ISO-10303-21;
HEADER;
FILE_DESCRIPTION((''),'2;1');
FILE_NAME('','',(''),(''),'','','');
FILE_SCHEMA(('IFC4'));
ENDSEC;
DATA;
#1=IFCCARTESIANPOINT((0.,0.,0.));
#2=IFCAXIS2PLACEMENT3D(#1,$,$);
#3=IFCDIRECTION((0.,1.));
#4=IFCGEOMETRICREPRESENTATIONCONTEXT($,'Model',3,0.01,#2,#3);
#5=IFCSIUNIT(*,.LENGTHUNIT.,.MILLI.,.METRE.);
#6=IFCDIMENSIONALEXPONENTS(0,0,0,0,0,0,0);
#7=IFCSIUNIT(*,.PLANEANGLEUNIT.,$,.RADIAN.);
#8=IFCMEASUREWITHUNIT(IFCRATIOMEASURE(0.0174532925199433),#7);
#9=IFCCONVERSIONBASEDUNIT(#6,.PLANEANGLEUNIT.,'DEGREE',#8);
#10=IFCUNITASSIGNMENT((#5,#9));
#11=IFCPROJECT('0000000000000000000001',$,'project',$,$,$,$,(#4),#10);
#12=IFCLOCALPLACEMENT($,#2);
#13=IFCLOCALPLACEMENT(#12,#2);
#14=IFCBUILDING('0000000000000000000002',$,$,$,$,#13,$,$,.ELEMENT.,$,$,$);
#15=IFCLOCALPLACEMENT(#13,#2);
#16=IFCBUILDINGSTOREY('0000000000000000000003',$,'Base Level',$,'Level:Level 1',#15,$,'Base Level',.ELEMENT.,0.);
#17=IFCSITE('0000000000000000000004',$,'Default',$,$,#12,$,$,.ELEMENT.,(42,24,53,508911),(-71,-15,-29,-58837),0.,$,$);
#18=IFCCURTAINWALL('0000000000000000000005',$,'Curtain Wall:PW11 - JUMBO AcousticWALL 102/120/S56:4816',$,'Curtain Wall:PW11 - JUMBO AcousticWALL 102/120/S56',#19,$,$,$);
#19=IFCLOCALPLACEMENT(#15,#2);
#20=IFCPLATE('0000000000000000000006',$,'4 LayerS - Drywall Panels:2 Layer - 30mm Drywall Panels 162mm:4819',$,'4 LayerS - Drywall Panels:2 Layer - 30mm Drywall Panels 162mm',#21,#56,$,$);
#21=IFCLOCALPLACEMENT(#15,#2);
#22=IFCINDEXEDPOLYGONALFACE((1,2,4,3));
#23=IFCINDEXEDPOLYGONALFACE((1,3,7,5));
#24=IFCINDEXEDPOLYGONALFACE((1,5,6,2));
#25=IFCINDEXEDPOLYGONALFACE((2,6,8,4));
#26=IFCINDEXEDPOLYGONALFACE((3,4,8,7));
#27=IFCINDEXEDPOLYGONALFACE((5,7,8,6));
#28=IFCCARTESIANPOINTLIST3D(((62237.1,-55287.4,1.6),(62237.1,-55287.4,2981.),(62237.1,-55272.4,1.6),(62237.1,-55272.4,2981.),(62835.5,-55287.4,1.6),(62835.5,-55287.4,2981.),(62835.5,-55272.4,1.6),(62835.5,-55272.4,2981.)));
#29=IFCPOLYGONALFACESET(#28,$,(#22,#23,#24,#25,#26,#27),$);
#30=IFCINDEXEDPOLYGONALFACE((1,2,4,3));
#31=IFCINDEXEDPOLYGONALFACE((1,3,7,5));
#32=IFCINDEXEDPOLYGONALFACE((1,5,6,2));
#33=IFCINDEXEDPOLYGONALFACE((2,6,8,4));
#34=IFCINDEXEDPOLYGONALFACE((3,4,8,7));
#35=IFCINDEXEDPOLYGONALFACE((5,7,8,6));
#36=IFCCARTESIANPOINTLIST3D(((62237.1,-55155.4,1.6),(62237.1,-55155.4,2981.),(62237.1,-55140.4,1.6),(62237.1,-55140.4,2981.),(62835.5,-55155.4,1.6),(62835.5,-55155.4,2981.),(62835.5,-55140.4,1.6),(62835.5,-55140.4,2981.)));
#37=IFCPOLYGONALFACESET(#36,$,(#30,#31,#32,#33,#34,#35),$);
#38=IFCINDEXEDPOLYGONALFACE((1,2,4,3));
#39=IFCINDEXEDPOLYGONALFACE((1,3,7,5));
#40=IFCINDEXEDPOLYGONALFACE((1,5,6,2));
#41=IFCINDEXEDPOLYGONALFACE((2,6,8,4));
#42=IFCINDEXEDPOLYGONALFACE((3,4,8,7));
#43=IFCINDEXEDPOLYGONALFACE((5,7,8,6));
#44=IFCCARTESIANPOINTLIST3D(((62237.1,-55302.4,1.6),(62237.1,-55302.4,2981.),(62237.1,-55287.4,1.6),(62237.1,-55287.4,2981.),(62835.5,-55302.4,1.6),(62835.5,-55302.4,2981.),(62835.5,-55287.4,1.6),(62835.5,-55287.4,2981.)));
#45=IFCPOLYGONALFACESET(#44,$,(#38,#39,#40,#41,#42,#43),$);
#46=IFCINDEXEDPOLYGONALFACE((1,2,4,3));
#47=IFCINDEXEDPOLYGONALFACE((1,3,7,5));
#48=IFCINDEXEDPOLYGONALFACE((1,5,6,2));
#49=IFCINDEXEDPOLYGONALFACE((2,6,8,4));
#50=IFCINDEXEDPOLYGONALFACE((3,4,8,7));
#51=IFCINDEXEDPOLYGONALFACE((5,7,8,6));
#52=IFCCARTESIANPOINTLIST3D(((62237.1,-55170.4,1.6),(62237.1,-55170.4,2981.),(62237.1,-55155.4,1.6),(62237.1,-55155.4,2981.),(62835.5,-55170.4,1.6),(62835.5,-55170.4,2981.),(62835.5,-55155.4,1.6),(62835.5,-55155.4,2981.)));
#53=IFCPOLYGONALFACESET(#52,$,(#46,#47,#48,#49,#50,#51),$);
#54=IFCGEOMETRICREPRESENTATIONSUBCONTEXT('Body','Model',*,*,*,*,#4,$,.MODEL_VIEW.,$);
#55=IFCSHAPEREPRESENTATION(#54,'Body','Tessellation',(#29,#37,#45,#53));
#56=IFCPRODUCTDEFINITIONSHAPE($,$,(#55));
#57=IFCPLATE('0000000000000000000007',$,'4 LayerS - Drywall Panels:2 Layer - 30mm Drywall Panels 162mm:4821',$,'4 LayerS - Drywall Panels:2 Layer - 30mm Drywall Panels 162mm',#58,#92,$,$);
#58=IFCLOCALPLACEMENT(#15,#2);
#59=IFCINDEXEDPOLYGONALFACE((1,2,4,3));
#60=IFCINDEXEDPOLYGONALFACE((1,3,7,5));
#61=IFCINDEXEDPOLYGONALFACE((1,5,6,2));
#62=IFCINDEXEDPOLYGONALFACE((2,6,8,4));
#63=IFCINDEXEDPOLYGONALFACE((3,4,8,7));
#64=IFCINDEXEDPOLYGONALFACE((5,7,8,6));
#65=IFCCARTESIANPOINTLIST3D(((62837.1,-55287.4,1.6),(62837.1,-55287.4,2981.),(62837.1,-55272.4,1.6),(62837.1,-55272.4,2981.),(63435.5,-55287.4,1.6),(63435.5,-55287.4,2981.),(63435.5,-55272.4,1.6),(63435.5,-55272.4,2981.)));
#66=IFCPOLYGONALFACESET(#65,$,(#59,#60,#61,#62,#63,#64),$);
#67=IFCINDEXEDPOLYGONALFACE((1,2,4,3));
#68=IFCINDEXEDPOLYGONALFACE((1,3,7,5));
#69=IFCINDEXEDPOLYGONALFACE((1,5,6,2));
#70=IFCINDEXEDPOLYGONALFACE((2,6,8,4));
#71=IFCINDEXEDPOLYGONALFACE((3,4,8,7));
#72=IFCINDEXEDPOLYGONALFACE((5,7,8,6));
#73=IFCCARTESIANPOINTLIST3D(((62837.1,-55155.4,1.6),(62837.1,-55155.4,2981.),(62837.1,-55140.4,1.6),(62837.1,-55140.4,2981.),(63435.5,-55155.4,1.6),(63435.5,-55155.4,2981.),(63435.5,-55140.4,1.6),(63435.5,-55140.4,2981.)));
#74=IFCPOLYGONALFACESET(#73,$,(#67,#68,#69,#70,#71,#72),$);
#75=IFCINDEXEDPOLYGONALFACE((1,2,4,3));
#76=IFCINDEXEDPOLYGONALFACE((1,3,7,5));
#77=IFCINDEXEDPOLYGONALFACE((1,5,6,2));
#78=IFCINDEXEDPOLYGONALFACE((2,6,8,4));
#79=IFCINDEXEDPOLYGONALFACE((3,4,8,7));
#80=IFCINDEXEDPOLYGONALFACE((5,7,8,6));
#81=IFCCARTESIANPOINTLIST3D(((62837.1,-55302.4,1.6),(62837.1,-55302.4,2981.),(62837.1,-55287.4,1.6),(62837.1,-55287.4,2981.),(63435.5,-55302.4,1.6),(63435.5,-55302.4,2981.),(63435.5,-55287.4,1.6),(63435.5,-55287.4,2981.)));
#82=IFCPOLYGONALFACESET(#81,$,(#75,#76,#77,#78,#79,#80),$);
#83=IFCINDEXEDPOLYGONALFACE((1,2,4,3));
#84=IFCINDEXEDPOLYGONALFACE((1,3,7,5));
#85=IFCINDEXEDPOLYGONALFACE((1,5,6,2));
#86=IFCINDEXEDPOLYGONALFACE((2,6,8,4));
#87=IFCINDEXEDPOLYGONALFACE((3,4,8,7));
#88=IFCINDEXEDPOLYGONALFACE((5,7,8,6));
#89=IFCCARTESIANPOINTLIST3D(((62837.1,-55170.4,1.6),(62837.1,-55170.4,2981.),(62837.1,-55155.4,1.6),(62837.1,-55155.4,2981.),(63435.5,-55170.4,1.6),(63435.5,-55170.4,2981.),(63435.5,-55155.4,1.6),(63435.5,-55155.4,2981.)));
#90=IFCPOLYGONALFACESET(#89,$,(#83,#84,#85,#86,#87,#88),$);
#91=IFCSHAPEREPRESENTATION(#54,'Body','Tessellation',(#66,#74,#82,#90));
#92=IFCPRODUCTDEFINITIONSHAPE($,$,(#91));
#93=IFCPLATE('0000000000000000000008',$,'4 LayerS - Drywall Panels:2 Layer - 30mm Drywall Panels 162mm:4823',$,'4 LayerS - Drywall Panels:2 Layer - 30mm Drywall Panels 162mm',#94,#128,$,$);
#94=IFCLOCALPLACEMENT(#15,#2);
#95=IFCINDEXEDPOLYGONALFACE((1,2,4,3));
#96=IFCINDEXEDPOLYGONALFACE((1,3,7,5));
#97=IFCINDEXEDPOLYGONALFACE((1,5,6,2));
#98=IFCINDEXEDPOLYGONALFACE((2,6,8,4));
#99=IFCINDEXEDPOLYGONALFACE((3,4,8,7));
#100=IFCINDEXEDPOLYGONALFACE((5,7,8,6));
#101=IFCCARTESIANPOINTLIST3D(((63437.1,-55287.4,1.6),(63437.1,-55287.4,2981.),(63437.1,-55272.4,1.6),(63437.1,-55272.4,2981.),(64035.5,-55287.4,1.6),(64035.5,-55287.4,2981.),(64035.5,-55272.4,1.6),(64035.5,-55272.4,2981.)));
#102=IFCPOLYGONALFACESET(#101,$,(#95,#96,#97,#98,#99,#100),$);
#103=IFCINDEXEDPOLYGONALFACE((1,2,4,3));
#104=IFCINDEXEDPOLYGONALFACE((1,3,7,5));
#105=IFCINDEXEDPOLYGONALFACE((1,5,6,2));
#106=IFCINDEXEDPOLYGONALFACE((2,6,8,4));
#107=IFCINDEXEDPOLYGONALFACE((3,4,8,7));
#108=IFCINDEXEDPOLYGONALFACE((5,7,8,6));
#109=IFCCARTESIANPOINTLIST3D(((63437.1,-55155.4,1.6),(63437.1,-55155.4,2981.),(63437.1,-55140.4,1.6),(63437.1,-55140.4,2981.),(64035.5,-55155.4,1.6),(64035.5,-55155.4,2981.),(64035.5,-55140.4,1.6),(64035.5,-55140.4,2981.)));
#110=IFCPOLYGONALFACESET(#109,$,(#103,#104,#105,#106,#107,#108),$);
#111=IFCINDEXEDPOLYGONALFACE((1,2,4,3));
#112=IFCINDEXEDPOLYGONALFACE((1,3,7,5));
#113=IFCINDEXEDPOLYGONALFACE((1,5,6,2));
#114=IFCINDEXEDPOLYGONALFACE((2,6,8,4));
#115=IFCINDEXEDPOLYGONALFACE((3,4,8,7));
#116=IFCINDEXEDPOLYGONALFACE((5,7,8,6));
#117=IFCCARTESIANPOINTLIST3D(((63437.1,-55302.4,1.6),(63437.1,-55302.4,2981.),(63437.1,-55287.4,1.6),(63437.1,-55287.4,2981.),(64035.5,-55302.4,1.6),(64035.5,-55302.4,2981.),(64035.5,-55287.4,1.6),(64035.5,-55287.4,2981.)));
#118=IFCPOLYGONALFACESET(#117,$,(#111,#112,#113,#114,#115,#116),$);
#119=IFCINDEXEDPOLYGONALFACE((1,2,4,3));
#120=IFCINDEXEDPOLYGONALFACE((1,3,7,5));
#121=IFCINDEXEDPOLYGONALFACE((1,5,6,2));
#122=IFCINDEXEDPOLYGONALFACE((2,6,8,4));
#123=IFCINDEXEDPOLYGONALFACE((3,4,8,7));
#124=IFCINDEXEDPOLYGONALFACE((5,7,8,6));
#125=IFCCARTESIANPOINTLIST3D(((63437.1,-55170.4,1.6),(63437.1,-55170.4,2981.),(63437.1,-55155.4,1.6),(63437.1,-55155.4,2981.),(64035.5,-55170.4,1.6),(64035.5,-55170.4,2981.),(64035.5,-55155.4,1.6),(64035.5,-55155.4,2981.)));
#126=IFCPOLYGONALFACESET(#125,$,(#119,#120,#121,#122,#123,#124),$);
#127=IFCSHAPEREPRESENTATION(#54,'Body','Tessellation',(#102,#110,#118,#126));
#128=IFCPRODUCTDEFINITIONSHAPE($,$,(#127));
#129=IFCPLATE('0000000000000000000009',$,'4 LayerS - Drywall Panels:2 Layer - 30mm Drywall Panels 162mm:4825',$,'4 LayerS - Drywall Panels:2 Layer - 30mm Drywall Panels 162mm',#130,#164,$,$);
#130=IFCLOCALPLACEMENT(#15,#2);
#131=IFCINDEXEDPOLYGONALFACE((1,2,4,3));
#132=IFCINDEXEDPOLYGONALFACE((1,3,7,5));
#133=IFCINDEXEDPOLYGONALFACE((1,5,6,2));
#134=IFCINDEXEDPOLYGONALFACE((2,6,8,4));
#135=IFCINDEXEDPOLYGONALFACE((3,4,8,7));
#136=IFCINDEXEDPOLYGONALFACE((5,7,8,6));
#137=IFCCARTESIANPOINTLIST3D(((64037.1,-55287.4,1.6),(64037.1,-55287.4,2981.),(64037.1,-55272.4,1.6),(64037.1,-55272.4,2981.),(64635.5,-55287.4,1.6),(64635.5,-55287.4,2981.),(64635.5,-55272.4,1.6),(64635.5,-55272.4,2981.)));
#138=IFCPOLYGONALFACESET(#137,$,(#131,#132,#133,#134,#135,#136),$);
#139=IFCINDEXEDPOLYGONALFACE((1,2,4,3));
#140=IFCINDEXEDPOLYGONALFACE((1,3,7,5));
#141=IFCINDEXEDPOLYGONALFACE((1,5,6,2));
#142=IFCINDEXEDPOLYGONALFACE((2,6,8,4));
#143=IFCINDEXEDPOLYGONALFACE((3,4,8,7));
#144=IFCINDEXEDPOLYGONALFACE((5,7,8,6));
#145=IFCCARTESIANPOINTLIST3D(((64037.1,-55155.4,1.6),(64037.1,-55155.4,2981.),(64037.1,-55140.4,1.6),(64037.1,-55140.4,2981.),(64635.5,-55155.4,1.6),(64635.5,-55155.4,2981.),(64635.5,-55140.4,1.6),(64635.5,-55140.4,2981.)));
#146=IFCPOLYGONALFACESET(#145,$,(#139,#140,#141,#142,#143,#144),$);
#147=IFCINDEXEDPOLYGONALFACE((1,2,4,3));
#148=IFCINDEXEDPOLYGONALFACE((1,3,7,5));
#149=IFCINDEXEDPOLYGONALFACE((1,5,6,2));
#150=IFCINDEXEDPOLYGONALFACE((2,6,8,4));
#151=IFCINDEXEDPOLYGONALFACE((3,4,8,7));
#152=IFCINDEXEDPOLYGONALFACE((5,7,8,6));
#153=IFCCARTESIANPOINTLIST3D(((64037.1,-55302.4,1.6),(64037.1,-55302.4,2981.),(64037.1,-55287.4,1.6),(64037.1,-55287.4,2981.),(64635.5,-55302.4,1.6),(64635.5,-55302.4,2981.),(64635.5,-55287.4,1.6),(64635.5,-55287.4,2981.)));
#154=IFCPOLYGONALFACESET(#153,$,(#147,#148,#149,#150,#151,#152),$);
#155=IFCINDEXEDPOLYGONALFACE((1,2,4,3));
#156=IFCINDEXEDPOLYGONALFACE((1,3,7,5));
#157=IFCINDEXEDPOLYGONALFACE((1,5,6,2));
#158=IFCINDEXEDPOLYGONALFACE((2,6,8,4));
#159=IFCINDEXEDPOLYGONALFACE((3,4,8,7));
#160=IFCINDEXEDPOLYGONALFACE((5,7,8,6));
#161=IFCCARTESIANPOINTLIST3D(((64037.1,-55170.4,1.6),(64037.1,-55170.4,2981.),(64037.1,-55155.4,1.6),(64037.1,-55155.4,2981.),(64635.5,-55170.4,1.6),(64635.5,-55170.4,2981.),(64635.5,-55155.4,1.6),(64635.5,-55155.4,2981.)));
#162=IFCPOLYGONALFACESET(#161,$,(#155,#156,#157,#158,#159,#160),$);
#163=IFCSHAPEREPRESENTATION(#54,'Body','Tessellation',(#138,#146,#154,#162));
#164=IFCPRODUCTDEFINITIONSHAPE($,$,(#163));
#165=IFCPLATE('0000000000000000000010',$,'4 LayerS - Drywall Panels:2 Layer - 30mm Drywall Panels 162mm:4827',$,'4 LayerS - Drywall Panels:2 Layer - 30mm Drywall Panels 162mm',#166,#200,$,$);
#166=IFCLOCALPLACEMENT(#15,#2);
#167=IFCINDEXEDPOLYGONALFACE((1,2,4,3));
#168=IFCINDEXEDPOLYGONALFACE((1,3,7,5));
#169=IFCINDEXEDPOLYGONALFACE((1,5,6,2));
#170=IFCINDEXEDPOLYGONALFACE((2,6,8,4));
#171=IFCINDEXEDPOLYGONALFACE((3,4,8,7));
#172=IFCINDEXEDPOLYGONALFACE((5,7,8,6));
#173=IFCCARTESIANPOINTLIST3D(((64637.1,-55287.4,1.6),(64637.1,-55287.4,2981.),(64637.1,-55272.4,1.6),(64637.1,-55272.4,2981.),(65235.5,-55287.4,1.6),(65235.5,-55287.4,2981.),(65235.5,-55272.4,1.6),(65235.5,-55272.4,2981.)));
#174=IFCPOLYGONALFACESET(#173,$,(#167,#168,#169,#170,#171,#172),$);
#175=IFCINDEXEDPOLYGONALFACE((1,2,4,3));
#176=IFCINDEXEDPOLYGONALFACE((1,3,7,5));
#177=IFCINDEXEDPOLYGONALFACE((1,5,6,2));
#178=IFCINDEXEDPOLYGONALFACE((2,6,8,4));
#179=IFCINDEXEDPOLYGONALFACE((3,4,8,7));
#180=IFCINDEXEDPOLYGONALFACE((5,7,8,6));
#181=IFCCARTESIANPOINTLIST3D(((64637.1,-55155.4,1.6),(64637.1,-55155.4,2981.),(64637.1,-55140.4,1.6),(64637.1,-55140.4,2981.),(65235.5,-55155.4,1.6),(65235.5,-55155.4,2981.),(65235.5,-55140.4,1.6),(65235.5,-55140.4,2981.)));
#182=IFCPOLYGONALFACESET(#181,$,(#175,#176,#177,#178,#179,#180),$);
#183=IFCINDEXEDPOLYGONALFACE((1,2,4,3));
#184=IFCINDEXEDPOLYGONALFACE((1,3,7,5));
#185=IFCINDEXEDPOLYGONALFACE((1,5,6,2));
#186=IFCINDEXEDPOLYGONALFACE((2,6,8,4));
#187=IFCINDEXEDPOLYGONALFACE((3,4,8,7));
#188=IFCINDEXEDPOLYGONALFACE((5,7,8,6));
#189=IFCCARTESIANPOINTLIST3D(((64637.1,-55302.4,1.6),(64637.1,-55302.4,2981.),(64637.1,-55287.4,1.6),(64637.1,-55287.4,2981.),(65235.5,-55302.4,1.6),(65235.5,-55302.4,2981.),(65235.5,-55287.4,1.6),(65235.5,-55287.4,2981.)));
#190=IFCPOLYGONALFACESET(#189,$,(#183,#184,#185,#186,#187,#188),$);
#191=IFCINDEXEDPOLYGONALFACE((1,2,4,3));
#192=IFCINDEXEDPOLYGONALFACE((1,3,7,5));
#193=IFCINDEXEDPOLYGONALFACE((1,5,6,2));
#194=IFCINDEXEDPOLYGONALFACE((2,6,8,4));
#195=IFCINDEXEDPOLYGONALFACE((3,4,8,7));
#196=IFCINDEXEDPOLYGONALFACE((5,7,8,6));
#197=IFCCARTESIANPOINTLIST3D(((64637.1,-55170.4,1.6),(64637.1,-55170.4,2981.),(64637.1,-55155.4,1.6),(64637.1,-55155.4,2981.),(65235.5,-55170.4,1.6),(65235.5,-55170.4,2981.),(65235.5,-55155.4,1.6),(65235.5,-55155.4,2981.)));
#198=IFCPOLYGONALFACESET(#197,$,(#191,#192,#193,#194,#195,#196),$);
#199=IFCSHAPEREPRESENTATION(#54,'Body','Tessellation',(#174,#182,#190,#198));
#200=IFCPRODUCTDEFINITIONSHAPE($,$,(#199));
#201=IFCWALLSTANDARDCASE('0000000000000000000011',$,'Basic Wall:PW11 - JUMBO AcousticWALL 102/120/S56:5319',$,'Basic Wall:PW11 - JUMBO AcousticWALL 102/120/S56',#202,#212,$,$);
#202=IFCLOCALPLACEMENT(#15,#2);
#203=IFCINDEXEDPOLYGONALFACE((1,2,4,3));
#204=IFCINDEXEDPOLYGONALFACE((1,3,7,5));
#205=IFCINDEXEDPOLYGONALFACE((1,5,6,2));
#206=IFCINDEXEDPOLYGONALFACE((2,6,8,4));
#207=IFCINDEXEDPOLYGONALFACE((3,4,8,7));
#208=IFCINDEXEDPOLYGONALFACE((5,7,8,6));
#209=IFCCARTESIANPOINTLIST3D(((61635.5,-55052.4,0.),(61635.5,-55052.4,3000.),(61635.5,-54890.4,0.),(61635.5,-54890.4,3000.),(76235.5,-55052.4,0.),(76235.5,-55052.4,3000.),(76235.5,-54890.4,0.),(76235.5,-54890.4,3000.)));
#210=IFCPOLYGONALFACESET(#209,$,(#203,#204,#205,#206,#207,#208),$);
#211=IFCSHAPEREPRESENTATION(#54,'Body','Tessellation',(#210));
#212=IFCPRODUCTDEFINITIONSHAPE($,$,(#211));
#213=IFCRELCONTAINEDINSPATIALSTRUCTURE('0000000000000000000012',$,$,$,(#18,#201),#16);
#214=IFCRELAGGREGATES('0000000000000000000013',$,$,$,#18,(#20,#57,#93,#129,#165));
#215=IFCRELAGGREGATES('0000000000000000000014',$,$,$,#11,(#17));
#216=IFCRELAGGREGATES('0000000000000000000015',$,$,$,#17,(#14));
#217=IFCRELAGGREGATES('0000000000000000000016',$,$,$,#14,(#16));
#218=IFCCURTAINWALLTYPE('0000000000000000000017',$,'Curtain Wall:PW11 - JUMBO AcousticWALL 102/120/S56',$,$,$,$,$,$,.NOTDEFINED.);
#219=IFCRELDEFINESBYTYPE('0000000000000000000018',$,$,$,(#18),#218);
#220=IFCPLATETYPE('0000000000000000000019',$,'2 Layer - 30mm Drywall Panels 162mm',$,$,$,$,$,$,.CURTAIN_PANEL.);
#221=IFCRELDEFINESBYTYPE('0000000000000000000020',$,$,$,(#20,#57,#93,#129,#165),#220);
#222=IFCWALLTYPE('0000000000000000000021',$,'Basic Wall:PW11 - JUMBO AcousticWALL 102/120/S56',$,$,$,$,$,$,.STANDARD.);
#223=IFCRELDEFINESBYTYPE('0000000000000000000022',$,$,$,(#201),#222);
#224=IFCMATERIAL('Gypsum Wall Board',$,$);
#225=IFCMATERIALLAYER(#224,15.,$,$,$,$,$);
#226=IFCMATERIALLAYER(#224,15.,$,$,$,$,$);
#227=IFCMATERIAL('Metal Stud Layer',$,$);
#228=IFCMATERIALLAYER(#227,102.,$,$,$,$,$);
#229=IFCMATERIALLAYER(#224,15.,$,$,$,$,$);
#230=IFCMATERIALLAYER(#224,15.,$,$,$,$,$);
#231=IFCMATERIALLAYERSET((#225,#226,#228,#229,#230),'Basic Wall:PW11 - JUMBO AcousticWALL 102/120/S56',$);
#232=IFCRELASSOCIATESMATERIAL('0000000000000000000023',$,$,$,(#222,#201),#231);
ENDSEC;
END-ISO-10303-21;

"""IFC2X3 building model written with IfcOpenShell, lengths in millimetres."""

from ifc_helpers import new_model, entity, si_unit, converted_unit, direction, frame, frame_2d, origin, origin_2d_with_axis, place, context, subcontext, project, spatial, rectangle, extrude, source, transform, mapped, material, layer, layer_set, layer_usage, type_object, type_shapes, element, aggregate, save


model = new_model("IFC2X3")

# Units and contexts
model_context = context("Model", 3, precision=0.01, world=origin(), true_north=direction((0.0, 1.0)))
body_context = subcontext(model_context, "Body", "Model", "MODEL_VIEW")
ifc_project = project(units=[si_unit("LENGTHUNIT", "METRE", prefix="MILLI"), converted_unit("PLANEANGLEUNIT", "DEGREE", entity("IfcRatioMeasure", 0.0174532925199433), si_unit("PLANEANGLEUNIT", "RADIAN"), dimensions=[0, 0, 0, 0, 0, 0, 0])], contexts=[model_context])

# Site, building, storey
site_placement = place(None, origin())
site = spatial("IfcSite", under=ifc_project, at=site_placement, Name="Default", CompositionType="ELEMENT", RefLatitude=(42, 24, 53, 508911), RefLongitude=(-71, -15, -29, -58837), RefElevation=0.0)
building_placement = place(site_placement, origin())
building = spatial("IfcBuilding", under=site, at=building_placement, CompositionType="ELEMENT")
storey_placement = place(building_placement, origin())
storey = spatial("IfcBuildingStorey", under=building, at=storey_placement, Name="Base Level", ObjectType="Level:Level 1", LongName="Base Level", CompositionType="ELEMENT", Elevation=0.0)

# Curtain wall, plates
curtain_wall_type = type_object("IfcCurtainWallType", Name="Curtain Wall:PW11 - JUMBO AcousticWALL 102/120/S56", PredefinedType="NOTDEFINED")
curtain_wall_placement = place(building_placement, origin())
curtain_wall = element("IfcCurtainWall", 1, at=curtain_wall_placement, inside=storey, type_object=curtain_wall_type, Name="Curtain Wall:PW11 - JUMBO AcousticWALL 102/120/S56:4816", ObjectType="Curtain Wall:PW11 - JUMBO AcousticWALL 102/120/S56")
plate_type = type_object("IfcPlateType", Name="2 Layer - 30mm Drywall Panels 162mm", PredefinedType="CURTAIN_PANEL")
shared_shape_1 = source(origin(), body_context, "Body", "SweptSolid", [
    extrude(rectangle(XDim=15.0, YDim=598.4, at=origin_2d_with_axis()), frame((0.0, -58.5, 0.0), z_axis=(0.0, 0.0, 1.0), x_axis=(0.0, 1.0, 0.0)), (0.0, 0.0, 1.0), 2979.4),
    extrude(rectangle(XDim=15.0, YDim=598.4, at=frame_2d((0.0, 0.0), x_axis=(1.0, 0.0))), frame((0.0, 73.5, 0.0), z_axis=(0.0, 0.0, 1.0), x_axis=(0.0, 1.0, 0.0)), (0.0, 0.0, 1.0), 2979.4),
    extrude(rectangle(XDim=598.4, YDim=15.0, at=origin_2d_with_axis()), frame((0.0, -73.5, 0.0), z_axis=(0.0, 0.0, 1.0), x_axis=(-1.0, 0.0, 0.0)), (0.0, 0.0, 1.0), 2979.4),
    extrude(rectangle(XDim=15.0, YDim=598.4, at=frame_2d((0.0, 0.0), x_axis=(1.0, 0.0))), frame((0.0, 58.5, 0.0), z_axis=(0.0, 0.0, 1.0), x_axis=(0.0, 1.0, 0.0)), (0.0, 0.0, 1.0), 2979.4),
])
type_shapes(plate_type, [shared_shape_1])
plate_1_placement = place(curtain_wall_placement, frame((62536.3, -55221.4, 1.6)))
plate_1 = element("IfcPlate", 2, at=plate_1_placement, type_object=plate_type, Name="4 LayerS - Drywall Panels:2 Layer - 30mm Drywall Panels 162mm:4819", ObjectType="4 LayerS - Drywall Panels:2 Layer - 30mm Drywall Panels 162mm", context=body_context, shape_type="MappedRepresentation", body=[
    mapped(shared_shape_1, transform((0.0, 0.0, 0.0), scale=1.0)),
])
plate_2_placement = place(curtain_wall_placement, frame((63136.3, -55221.4, 1.6)))
plate_2 = element("IfcPlate", 3, at=plate_2_placement, type_object=plate_type, Name="4 LayerS - Drywall Panels:2 Layer - 30mm Drywall Panels 162mm:4821", ObjectType="4 LayerS - Drywall Panels:2 Layer - 30mm Drywall Panels 162mm", context=body_context, shape_type="MappedRepresentation", body=[
    mapped(shared_shape_1, transform((0.0, 0.0, 0.0), scale=1.0)),
])
plate_3_placement = place(curtain_wall_placement, frame((63736.3, -55221.4, 1.6)))
plate_3 = element("IfcPlate", 4, at=plate_3_placement, type_object=plate_type, Name="4 LayerS - Drywall Panels:2 Layer - 30mm Drywall Panels 162mm:4823", ObjectType="4 LayerS - Drywall Panels:2 Layer - 30mm Drywall Panels 162mm", context=body_context, shape_type="MappedRepresentation", body=[
    mapped(shared_shape_1, transform((0.0, 0.0, 0.0), scale=1.0)),
])
plate_4_placement = place(curtain_wall_placement, frame((64336.3, -55221.4, 1.6)))
plate_4 = element("IfcPlate", 5, at=plate_4_placement, type_object=plate_type, Name="4 LayerS - Drywall Panels:2 Layer - 30mm Drywall Panels 162mm:4825", ObjectType="4 LayerS - Drywall Panels:2 Layer - 30mm Drywall Panels 162mm", context=body_context, shape_type="MappedRepresentation", body=[
    mapped(shared_shape_1, transform((0.0, 0.0, 0.0), scale=1.0)),
])
plate_5_placement = place(curtain_wall_placement, frame((64936.3, -55221.4, 1.6)))
plate_5 = element("IfcPlate", 6, at=plate_5_placement, type_object=plate_type, Name="4 LayerS - Drywall Panels:2 Layer - 30mm Drywall Panels 162mm:4827", ObjectType="4 LayerS - Drywall Panels:2 Layer - 30mm Drywall Panels 162mm", context=body_context, shape_type="MappedRepresentation", body=[
    mapped(shared_shape_1, transform((0.0, 0.0, 0.0), scale=1.0)),
])
aggregate(curtain_wall, [plate_1, plate_2, plate_3, plate_4, plate_5])

# Wall
ifc_material_1 = material(Name="Gypsum Wall Board")
ifc_layer_1 = layer(ifc_material_1, 15.0)
ifc_layer_2 = layer(ifc_material_1, 15.0)
ifc_material_2 = material(Name="Metal Stud Layer")
ifc_layer_3 = layer(ifc_material_2, 102.0)
ifc_layer_4 = layer(ifc_material_1, 15.0)
ifc_layer_5 = layer(ifc_material_1, 15.0)
ifc_layer_set = layer_set([ifc_layer_1, ifc_layer_2, ifc_layer_3, ifc_layer_4, ifc_layer_5], Name="Basic Wall:PW11 - JUMBO AcousticWALL 102/120/S56")
ifc_layer_usage = layer_usage(ifc_layer_set, "AXIS2", "NEGATIVE", 81.0)
wall_type = type_object("IfcWallType", Name="Basic Wall:PW11 - JUMBO AcousticWALL 102/120/S56", PredefinedType="STANDARD", material=ifc_layer_set)
wall_placement = place(building_placement, frame((61635.5, -54971.4, 0.0)))
element("IfcWallStandardCase", 7, at=wall_placement, inside=storey, type_object=wall_type, material=ifc_layer_usage, Name="Basic Wall:PW11 - JUMBO AcousticWALL 102/120/S56:5319", ObjectType="Basic Wall:PW11 - JUMBO AcousticWALL 102/120/S56", context=body_context, shape_type="SweptSolid", body=[
    extrude(rectangle(XDim=14600.0, YDim=162.0, at=frame_2d((7300.0, 0.0), x_axis=(-1.0, 0.0))), origin(), (0.0, 0.0, 1.0), 3000.0),
])

save(model, "model.ifc")
